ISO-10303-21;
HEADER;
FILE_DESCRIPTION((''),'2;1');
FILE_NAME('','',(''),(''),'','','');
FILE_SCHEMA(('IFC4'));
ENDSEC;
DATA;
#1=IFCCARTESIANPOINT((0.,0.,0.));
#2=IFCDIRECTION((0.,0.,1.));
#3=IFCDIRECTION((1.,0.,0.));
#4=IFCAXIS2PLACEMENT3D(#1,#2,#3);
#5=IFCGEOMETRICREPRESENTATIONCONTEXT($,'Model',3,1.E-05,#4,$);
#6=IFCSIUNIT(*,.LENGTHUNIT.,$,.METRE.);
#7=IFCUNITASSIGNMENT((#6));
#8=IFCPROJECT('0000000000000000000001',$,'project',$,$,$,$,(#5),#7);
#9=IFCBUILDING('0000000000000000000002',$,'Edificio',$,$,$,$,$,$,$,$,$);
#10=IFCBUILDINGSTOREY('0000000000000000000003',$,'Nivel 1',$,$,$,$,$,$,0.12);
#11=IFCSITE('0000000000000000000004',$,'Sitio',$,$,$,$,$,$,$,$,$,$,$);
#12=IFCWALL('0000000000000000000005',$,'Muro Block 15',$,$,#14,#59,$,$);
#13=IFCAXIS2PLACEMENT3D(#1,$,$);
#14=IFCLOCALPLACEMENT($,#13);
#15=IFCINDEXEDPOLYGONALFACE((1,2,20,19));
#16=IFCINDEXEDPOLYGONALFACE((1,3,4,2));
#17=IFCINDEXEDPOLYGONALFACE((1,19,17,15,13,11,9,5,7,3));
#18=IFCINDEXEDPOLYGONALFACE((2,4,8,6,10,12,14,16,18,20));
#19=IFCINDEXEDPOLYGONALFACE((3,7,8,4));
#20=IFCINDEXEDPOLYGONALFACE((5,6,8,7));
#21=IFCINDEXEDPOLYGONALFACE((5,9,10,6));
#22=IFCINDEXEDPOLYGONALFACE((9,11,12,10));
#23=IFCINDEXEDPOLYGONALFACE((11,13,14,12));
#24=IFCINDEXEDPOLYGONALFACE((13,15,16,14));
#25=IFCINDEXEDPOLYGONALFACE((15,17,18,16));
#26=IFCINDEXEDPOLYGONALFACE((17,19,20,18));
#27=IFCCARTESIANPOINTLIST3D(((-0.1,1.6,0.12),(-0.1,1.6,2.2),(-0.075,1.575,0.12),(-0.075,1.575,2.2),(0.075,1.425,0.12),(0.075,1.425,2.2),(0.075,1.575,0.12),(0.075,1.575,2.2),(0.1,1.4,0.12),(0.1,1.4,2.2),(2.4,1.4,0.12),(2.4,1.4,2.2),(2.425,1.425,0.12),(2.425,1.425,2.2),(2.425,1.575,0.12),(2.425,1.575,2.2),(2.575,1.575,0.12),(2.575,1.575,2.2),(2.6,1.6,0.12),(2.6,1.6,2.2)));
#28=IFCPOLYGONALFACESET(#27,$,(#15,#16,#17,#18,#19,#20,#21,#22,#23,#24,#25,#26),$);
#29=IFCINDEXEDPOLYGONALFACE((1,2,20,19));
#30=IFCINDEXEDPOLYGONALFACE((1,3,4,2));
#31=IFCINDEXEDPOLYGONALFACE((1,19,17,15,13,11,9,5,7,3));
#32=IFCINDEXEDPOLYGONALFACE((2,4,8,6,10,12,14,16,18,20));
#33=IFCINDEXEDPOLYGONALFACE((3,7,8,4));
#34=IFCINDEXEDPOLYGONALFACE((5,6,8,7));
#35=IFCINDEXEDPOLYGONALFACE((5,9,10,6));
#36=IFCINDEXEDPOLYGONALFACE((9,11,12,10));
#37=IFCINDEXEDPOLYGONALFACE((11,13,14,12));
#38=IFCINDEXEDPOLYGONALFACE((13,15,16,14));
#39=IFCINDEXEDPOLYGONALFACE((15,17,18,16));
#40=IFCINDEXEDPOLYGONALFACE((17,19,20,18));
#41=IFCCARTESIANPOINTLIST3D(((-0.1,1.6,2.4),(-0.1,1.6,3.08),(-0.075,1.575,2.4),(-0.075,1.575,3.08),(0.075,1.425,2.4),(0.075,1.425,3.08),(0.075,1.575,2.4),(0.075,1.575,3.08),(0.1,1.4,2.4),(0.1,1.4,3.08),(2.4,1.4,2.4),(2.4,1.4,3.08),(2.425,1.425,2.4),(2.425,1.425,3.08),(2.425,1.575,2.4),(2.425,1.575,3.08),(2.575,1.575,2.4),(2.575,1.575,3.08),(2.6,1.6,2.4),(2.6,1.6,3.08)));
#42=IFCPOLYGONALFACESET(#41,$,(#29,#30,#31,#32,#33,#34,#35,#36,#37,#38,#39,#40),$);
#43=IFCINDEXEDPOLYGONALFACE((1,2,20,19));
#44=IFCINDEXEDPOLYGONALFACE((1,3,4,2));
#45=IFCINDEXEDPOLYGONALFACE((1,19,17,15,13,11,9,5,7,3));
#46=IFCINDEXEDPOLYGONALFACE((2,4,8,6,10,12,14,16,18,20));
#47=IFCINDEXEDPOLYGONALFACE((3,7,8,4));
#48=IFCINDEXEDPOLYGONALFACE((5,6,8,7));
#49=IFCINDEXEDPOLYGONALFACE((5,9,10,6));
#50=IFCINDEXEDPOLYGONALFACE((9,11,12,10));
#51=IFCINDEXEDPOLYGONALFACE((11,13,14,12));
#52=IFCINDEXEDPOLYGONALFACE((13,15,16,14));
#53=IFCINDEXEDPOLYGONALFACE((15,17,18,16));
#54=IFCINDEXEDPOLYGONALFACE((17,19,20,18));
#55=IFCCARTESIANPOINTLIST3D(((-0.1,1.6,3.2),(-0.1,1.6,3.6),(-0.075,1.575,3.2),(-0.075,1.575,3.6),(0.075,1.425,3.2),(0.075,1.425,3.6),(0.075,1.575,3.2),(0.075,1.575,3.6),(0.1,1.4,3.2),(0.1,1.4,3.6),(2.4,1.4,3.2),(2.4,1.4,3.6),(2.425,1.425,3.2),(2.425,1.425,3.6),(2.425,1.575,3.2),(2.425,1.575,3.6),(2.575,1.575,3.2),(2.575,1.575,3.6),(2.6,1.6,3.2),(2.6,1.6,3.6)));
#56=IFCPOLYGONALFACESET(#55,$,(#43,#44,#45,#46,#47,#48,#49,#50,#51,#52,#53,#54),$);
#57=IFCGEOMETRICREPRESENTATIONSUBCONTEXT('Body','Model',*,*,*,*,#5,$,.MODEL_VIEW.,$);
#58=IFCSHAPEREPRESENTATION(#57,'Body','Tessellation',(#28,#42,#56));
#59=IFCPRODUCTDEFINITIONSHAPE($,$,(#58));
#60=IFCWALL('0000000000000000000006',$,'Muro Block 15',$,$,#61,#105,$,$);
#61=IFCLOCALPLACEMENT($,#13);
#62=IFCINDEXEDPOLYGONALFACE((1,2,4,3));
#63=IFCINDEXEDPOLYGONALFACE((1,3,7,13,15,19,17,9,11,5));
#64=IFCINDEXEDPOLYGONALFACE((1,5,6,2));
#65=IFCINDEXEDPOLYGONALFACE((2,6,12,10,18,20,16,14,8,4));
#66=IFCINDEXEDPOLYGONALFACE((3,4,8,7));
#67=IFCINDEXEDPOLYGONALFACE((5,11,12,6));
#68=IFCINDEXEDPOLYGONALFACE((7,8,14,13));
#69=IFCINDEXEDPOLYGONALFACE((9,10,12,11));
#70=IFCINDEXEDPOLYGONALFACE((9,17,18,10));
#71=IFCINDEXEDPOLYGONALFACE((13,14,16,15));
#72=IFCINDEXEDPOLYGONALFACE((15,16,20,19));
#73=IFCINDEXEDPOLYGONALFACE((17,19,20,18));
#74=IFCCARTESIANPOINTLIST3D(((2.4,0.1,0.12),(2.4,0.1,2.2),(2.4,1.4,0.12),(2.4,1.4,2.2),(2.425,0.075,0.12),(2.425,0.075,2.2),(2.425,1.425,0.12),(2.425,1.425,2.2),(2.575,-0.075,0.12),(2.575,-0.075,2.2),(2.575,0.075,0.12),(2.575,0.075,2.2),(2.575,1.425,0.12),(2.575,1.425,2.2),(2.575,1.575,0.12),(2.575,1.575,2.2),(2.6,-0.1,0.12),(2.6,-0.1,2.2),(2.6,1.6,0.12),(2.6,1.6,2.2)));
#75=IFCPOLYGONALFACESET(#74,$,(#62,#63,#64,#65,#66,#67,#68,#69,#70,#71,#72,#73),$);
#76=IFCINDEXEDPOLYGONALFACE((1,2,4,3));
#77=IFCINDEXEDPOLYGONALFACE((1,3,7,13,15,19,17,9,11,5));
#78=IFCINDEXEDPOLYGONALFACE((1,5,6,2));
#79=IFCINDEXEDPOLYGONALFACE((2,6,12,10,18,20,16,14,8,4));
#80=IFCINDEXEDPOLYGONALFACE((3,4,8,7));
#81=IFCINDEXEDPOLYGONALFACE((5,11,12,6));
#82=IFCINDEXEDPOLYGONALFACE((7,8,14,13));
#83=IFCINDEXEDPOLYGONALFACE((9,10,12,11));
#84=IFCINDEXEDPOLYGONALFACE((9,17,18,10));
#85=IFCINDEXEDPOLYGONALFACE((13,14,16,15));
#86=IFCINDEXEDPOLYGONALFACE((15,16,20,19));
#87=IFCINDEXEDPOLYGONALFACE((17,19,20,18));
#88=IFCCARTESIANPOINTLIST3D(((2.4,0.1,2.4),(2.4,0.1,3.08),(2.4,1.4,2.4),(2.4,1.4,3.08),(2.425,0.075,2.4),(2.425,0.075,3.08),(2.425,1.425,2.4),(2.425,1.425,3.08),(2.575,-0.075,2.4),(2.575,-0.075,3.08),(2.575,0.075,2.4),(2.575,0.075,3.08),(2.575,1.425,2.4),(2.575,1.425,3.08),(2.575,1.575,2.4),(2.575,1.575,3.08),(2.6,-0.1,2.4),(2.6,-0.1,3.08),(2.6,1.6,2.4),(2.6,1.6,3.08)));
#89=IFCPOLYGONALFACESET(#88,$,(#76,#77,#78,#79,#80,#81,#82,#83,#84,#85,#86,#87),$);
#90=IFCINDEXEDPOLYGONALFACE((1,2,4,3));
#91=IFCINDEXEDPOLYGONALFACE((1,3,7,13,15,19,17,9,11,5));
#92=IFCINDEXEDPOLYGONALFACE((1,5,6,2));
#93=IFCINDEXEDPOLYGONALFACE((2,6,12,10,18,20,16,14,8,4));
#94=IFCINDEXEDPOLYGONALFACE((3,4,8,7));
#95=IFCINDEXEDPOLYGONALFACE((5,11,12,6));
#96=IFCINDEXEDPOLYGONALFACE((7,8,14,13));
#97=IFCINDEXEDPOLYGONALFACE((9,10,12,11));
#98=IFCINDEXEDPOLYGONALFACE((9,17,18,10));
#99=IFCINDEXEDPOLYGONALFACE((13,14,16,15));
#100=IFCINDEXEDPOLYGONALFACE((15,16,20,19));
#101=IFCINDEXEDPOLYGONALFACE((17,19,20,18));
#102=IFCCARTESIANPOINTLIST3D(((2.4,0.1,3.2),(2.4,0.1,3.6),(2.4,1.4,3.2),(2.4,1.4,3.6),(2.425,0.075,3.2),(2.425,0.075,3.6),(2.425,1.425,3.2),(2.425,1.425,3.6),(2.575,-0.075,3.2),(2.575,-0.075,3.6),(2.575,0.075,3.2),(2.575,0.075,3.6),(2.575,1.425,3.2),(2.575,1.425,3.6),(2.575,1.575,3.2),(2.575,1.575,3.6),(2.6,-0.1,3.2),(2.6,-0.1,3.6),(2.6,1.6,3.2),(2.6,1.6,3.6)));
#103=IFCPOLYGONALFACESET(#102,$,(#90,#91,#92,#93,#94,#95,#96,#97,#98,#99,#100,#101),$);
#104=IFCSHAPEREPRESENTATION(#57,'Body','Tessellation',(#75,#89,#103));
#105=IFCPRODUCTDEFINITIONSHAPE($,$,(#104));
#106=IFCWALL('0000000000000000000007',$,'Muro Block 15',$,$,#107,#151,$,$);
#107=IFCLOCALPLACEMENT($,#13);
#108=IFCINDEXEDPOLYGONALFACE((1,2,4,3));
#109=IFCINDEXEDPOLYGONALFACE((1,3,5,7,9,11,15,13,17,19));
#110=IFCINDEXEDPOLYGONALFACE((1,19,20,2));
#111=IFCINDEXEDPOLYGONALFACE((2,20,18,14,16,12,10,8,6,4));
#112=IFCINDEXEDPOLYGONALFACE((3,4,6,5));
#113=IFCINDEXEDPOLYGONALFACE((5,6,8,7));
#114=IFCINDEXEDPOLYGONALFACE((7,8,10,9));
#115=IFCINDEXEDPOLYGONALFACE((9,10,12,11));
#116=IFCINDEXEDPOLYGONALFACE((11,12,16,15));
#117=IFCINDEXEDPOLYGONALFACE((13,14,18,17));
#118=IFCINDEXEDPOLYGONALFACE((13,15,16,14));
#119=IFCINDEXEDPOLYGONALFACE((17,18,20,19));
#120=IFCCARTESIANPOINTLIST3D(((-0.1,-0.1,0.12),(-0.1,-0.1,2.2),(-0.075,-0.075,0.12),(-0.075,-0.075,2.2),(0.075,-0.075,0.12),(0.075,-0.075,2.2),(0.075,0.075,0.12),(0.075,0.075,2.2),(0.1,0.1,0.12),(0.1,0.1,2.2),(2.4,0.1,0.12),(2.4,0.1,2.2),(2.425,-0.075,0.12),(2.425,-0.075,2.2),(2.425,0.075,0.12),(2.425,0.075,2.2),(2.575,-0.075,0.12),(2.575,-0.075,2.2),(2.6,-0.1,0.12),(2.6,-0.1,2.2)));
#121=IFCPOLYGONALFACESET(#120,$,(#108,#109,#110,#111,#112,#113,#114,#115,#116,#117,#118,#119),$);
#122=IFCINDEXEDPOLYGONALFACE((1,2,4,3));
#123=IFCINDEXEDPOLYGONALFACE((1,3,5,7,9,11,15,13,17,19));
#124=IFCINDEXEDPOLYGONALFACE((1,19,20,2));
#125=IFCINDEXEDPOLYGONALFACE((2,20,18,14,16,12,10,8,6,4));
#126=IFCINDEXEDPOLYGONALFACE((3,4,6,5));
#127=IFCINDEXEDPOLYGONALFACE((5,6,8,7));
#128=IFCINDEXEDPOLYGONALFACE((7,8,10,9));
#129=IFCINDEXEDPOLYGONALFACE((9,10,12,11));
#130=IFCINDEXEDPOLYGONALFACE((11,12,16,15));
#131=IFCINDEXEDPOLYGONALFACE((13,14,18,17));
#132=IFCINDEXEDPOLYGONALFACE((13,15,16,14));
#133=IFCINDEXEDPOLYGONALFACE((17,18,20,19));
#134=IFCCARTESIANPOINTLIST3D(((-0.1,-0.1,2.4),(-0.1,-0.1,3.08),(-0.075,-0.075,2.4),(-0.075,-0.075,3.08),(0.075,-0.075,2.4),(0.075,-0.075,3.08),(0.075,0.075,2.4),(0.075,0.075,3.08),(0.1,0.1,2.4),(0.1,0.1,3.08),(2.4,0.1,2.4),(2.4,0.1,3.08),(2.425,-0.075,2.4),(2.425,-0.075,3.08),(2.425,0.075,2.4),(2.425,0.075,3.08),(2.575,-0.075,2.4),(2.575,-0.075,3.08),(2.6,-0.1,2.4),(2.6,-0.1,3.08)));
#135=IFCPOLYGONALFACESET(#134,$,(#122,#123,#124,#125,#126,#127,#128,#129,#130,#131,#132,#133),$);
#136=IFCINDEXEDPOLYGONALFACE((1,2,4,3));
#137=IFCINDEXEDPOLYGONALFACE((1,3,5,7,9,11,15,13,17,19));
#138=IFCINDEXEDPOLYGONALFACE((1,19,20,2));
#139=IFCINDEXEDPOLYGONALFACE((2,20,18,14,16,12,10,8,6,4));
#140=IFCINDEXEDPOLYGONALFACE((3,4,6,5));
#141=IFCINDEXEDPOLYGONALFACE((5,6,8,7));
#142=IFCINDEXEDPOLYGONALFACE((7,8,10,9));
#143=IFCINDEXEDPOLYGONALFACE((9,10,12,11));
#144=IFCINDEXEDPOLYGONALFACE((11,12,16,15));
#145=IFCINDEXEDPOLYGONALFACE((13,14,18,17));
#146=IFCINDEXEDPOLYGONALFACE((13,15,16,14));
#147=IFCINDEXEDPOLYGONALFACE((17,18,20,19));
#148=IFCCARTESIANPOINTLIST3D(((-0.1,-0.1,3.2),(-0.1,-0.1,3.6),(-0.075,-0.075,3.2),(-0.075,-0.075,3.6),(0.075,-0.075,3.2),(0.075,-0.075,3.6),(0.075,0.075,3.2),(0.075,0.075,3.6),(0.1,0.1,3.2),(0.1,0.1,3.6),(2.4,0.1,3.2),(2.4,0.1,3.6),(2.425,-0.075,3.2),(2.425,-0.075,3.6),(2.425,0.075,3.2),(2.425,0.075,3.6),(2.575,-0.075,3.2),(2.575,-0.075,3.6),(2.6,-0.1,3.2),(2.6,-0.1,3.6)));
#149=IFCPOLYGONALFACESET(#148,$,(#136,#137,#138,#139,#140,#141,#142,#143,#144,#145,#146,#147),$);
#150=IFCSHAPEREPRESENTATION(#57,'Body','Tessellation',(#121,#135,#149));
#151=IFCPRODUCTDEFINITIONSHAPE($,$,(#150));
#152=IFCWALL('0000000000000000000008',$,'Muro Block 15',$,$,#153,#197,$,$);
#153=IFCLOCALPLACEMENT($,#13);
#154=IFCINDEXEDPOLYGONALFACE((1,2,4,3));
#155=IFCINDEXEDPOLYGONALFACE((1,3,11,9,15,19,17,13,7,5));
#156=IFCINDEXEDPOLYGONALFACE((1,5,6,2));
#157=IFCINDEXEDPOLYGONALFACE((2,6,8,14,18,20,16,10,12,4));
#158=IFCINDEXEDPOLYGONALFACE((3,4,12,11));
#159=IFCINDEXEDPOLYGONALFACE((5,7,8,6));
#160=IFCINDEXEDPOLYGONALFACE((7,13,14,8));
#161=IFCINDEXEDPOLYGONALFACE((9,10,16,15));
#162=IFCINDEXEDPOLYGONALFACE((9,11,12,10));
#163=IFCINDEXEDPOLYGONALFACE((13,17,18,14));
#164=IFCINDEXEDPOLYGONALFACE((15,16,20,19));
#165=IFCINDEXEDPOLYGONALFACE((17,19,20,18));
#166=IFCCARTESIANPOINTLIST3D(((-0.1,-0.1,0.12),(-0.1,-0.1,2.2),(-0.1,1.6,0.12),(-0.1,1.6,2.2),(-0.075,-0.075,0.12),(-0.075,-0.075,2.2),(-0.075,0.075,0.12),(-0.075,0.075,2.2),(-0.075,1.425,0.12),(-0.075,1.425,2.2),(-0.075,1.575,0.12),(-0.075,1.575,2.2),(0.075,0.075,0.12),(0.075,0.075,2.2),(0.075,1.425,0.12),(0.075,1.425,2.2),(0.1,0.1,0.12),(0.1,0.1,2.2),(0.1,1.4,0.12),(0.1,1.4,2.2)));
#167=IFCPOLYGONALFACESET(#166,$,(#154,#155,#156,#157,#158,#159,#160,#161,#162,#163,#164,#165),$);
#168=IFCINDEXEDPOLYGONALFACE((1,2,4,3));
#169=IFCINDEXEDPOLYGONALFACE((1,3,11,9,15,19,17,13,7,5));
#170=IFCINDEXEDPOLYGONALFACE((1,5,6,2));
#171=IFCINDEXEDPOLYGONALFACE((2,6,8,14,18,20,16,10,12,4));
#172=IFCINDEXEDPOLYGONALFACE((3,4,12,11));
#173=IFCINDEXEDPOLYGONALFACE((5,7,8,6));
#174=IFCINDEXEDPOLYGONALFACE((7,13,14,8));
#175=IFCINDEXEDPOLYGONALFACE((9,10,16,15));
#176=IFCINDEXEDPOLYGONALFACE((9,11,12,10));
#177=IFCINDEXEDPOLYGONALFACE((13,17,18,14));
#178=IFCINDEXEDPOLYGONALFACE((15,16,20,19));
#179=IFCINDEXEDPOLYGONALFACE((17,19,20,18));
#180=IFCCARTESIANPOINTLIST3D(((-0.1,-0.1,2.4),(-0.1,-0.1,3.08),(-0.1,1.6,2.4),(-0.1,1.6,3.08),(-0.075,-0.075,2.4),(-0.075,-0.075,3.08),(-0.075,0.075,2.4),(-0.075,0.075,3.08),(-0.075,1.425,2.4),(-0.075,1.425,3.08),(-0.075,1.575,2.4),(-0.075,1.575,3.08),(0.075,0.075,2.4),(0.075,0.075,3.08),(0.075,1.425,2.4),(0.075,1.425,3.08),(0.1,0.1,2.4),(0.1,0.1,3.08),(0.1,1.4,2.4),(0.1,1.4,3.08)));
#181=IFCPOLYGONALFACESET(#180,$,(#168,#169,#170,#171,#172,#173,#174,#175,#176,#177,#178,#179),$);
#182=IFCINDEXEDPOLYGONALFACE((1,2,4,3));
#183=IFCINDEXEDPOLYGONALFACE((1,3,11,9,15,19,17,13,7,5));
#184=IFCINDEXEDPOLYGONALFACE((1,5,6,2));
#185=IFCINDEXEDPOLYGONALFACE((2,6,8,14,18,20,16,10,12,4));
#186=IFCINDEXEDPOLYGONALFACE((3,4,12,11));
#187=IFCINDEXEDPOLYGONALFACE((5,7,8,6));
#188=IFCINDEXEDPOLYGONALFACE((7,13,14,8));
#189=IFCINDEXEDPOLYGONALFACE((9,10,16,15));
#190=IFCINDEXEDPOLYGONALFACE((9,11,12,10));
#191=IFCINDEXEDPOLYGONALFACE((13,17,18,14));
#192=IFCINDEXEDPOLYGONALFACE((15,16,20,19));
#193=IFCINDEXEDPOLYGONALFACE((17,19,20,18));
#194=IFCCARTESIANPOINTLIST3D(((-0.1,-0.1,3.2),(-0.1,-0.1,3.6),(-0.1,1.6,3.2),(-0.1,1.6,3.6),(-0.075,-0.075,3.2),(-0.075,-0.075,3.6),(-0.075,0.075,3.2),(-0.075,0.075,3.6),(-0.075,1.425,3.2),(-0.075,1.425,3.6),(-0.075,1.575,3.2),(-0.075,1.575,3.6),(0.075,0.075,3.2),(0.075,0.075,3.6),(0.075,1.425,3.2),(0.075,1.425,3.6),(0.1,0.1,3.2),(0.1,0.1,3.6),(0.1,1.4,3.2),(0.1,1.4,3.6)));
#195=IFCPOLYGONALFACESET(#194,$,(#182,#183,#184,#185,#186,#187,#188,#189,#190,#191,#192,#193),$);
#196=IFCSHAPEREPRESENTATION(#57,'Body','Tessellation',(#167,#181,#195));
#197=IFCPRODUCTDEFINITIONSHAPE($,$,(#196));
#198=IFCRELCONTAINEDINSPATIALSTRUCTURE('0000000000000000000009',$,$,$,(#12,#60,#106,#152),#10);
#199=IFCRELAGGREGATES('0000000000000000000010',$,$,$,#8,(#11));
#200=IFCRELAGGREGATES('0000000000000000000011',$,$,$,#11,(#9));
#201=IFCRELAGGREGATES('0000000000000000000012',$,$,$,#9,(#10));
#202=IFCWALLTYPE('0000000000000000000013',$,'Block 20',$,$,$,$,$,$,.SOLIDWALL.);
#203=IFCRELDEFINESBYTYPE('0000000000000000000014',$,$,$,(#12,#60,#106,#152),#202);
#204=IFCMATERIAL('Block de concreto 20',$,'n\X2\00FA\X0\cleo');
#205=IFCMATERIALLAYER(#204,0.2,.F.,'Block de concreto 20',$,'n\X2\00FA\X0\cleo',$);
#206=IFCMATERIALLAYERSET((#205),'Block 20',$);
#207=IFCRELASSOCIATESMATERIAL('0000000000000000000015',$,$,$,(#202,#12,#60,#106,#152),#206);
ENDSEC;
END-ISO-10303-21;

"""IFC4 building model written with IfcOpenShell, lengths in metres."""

from ifc_helpers import new_model, si_unit, frame, origin_with_axes, place, context, subcontext, project, spatial, indexed_curve, outline, extrude, material, layer, layer_set, layer_usage, type_object, element, save


model = new_model("IFC4")

# Units and contexts
model_context = context("Model", 3, precision=1e-05, world=origin_with_axes())
body_context = subcontext(model_context, "Body", "Model", "MODEL_VIEW")
ifc_project = project(units=[si_unit("LENGTHUNIT", "METRE")], contexts=[model_context])

# Site, building, storey
site = spatial("IfcSite", under=ifc_project, Name="Sitio")
building = spatial("IfcBuilding", under=site, Name="Edificio")
storey = spatial("IfcBuildingStorey", under=building, Name="Nivel 1", Elevation=0.12)

# Walls
ifc_material = material(Name="Block de concreto 20", Category="núcleo")
ifc_layer = layer(ifc_material, 0.2, ventilated=False, Name="Block de concreto 20", Category="núcleo")
ifc_layer_set = layer_set([ifc_layer], Name="Block 20")
ifc_layer_usage_1 = layer_usage(ifc_layer_set, "AXIS2", "POSITIVE", 0.0)
wall_type = type_object("IfcWallType", Name="Block 20", PredefinedType="SOLIDWALL", material=ifc_layer_set)
wall_1_placement = place(None, frame((0.0, 1.5, 0.12), z_axis=(0.0, 0.0, 1.0), x_axis=(1.0, 0.0, 0.0)))
element("IfcWall", 1, at=wall_1_placement, inside=storey, type_object=wall_type, material=ifc_layer_usage_1, Name="Muro Block 15", context=body_context, shape_type="SweptSolid", body=[
    extrude(outline(indexed_curve([(2.6, 0.1), (2.575, 0.075), (2.425, 0.075), (2.425, -0.075), (2.4, -0.1), (0.1, -0.1), (0.075, -0.075), (0.075, 0.075), (-0.075, 0.075), (-0.1, 0.1)])), None, (0.0, 0.0, 1.0), 2.08),
    extrude(outline(indexed_curve([(2.6, 0.1), (2.575, 0.075), (2.425, 0.075), (2.425, -0.075), (2.4, -0.1), (0.1, -0.1), (0.075, -0.075), (0.075, 0.075), (-0.075, 0.075), (-0.1, 0.1)])), frame((0.0, 0.0, 2.28), z_axis=(0.0, 0.0, 1.0), x_axis=(1.0, 0.0, 0.0)), (0.0, 0.0, 1.0), 0.68),
    extrude(outline(indexed_curve([(2.6, 0.1), (2.575, 0.075), (2.425, 0.075), (2.425, -0.075), (2.4, -0.1), (0.1, -0.1), (0.075, -0.075), (0.075, 0.075), (-0.075, 0.075), (-0.1, 0.1)])), frame((0.0, 0.0, 3.08), z_axis=(0.0, 0.0, 1.0), x_axis=(1.0, 0.0, 0.0)), (0.0, 0.0, 1.0), 0.4),
])
ifc_layer_usage_2 = layer_usage(ifc_layer_set, "AXIS2", "POSITIVE", 0.0)
wall_2_placement = place(None, frame((2.5, 1.5, 0.12), z_axis=(0.0, 0.0, 1.0), x_axis=(0.0, -1.0, 0.0)))
element("IfcWall", 2, at=wall_2_placement, inside=storey, type_object=wall_type, material=ifc_layer_usage_2, Name="Muro Block 15", context=body_context, shape_type="SweptSolid", body=[
    extrude(outline(indexed_curve([(1.6, 0.1), (1.575, 0.075), (1.425, 0.075), (1.425, -0.075), (1.4, -0.1), (0.1, -0.1), (0.075, -0.075), (0.075, 0.075), (-0.075, 0.075), (-0.1, 0.1)])), None, (0.0, 0.0, 1.0), 2.08),
    extrude(outline(indexed_curve([(1.6, 0.1), (1.575, 0.075), (1.425, 0.075), (1.425, -0.075), (1.4, -0.1), (0.1, -0.1), (0.075, -0.075), (0.075, 0.075), (-0.075, 0.075), (-0.1, 0.1)])), frame((0.0, 0.0, 2.28), z_axis=(0.0, 0.0, 1.0), x_axis=(1.0, 0.0, 0.0)), (0.0, 0.0, 1.0), 0.68),
    extrude(outline(indexed_curve([(1.6, 0.1), (1.575, 0.075), (1.425, 0.075), (1.425, -0.075), (1.4, -0.1), (0.1, -0.1), (0.075, -0.075), (0.075, 0.075), (-0.075, 0.075), (-0.1, 0.1)])), frame((0.0, 0.0, 3.08), z_axis=(0.0, 0.0, 1.0), x_axis=(1.0, 0.0, 0.0)), (0.0, 0.0, 1.0), 0.4),
])
ifc_layer_usage_3 = layer_usage(ifc_layer_set, "AXIS2", "POSITIVE", 0.0)
wall_3_placement = place(None, frame((2.5, 0.0, 0.12), z_axis=(0.0, 0.0, 1.0), x_axis=(-1.0, 0.0, 0.0)))
element("IfcWall", 3, at=wall_3_placement, inside=storey, type_object=wall_type, material=ifc_layer_usage_3, Name="Muro Block 15", context=body_context, shape_type="SweptSolid", body=[
    extrude(outline(indexed_curve([(2.6, 0.1), (2.575, 0.075), (2.425, 0.075), (2.425, -0.075), (2.4, -0.1), (0.1, -0.1), (0.075, -0.075), (0.075, 0.075), (-0.075, 0.075), (-0.1, 0.1)])), None, (0.0, 0.0, 1.0), 2.08),
    extrude(outline(indexed_curve([(2.6, 0.1), (2.575, 0.075), (2.425, 0.075), (2.425, -0.075), (2.4, -0.1), (0.1, -0.1), (0.075, -0.075), (0.075, 0.075), (-0.075, 0.075), (-0.1, 0.1)])), frame((0.0, 0.0, 2.28), z_axis=(0.0, 0.0, 1.0), x_axis=(1.0, 0.0, 0.0)), (0.0, 0.0, 1.0), 0.68),
    extrude(outline(indexed_curve([(2.6, 0.1), (2.575, 0.075), (2.425, 0.075), (2.425, -0.075), (2.4, -0.1), (0.1, -0.1), (0.075, -0.075), (0.075, 0.075), (-0.075, 0.075), (-0.1, 0.1)])), frame((0.0, 0.0, 3.08), z_axis=(0.0, 0.0, 1.0), x_axis=(1.0, 0.0, 0.0)), (0.0, 0.0, 1.0), 0.4),
])
ifc_layer_usage_4 = layer_usage(ifc_layer_set, "AXIS2", "POSITIVE", 0.0)
wall_4_placement = place(None, frame((0.0, 0.0, 0.12), z_axis=(0.0, 0.0, 1.0), x_axis=(0.0, 1.0, 0.0)))
element("IfcWall", 4, at=wall_4_placement, inside=storey, type_object=wall_type, material=ifc_layer_usage_4, Name="Muro Block 15", context=body_context, shape_type="SweptSolid", body=[
    extrude(outline(indexed_curve([(0.1, -0.1), (0.075, -0.075), (0.075, 0.075), (-0.075, 0.075), (-0.1, 0.1), (1.6, 0.1), (1.575, 0.075), (1.425, 0.075), (1.425, -0.075), (1.4, -0.1)])), None, (0.0, 0.0, 1.0), 2.08),
    extrude(outline(indexed_curve([(0.1, -0.1), (0.075, -0.075), (0.075, 0.075), (-0.075, 0.075), (-0.1, 0.1), (1.6, 0.1), (1.575, 0.075), (1.425, 0.075), (1.425, -0.075), (1.4, -0.1)])), frame((0.0, 0.0, 2.28), z_axis=(0.0, 0.0, 1.0), x_axis=(1.0, 0.0, 0.0)), (0.0, 0.0, 1.0), 0.68),
    extrude(outline(indexed_curve([(0.1, -0.1), (0.075, -0.075), (0.075, 0.075), (-0.075, 0.075), (-0.1, 0.1), (1.6, 0.1), (1.575, 0.075), (1.425, 0.075), (1.425, -0.075), (1.4, -0.1)])), frame((0.0, 0.0, 3.08), z_axis=(0.0, 0.0, 1.0), x_axis=(1.0, 0.0, 0.0)), (0.0, 0.0, 1.0), 0.4),
])

save(model, "model.ifc")
